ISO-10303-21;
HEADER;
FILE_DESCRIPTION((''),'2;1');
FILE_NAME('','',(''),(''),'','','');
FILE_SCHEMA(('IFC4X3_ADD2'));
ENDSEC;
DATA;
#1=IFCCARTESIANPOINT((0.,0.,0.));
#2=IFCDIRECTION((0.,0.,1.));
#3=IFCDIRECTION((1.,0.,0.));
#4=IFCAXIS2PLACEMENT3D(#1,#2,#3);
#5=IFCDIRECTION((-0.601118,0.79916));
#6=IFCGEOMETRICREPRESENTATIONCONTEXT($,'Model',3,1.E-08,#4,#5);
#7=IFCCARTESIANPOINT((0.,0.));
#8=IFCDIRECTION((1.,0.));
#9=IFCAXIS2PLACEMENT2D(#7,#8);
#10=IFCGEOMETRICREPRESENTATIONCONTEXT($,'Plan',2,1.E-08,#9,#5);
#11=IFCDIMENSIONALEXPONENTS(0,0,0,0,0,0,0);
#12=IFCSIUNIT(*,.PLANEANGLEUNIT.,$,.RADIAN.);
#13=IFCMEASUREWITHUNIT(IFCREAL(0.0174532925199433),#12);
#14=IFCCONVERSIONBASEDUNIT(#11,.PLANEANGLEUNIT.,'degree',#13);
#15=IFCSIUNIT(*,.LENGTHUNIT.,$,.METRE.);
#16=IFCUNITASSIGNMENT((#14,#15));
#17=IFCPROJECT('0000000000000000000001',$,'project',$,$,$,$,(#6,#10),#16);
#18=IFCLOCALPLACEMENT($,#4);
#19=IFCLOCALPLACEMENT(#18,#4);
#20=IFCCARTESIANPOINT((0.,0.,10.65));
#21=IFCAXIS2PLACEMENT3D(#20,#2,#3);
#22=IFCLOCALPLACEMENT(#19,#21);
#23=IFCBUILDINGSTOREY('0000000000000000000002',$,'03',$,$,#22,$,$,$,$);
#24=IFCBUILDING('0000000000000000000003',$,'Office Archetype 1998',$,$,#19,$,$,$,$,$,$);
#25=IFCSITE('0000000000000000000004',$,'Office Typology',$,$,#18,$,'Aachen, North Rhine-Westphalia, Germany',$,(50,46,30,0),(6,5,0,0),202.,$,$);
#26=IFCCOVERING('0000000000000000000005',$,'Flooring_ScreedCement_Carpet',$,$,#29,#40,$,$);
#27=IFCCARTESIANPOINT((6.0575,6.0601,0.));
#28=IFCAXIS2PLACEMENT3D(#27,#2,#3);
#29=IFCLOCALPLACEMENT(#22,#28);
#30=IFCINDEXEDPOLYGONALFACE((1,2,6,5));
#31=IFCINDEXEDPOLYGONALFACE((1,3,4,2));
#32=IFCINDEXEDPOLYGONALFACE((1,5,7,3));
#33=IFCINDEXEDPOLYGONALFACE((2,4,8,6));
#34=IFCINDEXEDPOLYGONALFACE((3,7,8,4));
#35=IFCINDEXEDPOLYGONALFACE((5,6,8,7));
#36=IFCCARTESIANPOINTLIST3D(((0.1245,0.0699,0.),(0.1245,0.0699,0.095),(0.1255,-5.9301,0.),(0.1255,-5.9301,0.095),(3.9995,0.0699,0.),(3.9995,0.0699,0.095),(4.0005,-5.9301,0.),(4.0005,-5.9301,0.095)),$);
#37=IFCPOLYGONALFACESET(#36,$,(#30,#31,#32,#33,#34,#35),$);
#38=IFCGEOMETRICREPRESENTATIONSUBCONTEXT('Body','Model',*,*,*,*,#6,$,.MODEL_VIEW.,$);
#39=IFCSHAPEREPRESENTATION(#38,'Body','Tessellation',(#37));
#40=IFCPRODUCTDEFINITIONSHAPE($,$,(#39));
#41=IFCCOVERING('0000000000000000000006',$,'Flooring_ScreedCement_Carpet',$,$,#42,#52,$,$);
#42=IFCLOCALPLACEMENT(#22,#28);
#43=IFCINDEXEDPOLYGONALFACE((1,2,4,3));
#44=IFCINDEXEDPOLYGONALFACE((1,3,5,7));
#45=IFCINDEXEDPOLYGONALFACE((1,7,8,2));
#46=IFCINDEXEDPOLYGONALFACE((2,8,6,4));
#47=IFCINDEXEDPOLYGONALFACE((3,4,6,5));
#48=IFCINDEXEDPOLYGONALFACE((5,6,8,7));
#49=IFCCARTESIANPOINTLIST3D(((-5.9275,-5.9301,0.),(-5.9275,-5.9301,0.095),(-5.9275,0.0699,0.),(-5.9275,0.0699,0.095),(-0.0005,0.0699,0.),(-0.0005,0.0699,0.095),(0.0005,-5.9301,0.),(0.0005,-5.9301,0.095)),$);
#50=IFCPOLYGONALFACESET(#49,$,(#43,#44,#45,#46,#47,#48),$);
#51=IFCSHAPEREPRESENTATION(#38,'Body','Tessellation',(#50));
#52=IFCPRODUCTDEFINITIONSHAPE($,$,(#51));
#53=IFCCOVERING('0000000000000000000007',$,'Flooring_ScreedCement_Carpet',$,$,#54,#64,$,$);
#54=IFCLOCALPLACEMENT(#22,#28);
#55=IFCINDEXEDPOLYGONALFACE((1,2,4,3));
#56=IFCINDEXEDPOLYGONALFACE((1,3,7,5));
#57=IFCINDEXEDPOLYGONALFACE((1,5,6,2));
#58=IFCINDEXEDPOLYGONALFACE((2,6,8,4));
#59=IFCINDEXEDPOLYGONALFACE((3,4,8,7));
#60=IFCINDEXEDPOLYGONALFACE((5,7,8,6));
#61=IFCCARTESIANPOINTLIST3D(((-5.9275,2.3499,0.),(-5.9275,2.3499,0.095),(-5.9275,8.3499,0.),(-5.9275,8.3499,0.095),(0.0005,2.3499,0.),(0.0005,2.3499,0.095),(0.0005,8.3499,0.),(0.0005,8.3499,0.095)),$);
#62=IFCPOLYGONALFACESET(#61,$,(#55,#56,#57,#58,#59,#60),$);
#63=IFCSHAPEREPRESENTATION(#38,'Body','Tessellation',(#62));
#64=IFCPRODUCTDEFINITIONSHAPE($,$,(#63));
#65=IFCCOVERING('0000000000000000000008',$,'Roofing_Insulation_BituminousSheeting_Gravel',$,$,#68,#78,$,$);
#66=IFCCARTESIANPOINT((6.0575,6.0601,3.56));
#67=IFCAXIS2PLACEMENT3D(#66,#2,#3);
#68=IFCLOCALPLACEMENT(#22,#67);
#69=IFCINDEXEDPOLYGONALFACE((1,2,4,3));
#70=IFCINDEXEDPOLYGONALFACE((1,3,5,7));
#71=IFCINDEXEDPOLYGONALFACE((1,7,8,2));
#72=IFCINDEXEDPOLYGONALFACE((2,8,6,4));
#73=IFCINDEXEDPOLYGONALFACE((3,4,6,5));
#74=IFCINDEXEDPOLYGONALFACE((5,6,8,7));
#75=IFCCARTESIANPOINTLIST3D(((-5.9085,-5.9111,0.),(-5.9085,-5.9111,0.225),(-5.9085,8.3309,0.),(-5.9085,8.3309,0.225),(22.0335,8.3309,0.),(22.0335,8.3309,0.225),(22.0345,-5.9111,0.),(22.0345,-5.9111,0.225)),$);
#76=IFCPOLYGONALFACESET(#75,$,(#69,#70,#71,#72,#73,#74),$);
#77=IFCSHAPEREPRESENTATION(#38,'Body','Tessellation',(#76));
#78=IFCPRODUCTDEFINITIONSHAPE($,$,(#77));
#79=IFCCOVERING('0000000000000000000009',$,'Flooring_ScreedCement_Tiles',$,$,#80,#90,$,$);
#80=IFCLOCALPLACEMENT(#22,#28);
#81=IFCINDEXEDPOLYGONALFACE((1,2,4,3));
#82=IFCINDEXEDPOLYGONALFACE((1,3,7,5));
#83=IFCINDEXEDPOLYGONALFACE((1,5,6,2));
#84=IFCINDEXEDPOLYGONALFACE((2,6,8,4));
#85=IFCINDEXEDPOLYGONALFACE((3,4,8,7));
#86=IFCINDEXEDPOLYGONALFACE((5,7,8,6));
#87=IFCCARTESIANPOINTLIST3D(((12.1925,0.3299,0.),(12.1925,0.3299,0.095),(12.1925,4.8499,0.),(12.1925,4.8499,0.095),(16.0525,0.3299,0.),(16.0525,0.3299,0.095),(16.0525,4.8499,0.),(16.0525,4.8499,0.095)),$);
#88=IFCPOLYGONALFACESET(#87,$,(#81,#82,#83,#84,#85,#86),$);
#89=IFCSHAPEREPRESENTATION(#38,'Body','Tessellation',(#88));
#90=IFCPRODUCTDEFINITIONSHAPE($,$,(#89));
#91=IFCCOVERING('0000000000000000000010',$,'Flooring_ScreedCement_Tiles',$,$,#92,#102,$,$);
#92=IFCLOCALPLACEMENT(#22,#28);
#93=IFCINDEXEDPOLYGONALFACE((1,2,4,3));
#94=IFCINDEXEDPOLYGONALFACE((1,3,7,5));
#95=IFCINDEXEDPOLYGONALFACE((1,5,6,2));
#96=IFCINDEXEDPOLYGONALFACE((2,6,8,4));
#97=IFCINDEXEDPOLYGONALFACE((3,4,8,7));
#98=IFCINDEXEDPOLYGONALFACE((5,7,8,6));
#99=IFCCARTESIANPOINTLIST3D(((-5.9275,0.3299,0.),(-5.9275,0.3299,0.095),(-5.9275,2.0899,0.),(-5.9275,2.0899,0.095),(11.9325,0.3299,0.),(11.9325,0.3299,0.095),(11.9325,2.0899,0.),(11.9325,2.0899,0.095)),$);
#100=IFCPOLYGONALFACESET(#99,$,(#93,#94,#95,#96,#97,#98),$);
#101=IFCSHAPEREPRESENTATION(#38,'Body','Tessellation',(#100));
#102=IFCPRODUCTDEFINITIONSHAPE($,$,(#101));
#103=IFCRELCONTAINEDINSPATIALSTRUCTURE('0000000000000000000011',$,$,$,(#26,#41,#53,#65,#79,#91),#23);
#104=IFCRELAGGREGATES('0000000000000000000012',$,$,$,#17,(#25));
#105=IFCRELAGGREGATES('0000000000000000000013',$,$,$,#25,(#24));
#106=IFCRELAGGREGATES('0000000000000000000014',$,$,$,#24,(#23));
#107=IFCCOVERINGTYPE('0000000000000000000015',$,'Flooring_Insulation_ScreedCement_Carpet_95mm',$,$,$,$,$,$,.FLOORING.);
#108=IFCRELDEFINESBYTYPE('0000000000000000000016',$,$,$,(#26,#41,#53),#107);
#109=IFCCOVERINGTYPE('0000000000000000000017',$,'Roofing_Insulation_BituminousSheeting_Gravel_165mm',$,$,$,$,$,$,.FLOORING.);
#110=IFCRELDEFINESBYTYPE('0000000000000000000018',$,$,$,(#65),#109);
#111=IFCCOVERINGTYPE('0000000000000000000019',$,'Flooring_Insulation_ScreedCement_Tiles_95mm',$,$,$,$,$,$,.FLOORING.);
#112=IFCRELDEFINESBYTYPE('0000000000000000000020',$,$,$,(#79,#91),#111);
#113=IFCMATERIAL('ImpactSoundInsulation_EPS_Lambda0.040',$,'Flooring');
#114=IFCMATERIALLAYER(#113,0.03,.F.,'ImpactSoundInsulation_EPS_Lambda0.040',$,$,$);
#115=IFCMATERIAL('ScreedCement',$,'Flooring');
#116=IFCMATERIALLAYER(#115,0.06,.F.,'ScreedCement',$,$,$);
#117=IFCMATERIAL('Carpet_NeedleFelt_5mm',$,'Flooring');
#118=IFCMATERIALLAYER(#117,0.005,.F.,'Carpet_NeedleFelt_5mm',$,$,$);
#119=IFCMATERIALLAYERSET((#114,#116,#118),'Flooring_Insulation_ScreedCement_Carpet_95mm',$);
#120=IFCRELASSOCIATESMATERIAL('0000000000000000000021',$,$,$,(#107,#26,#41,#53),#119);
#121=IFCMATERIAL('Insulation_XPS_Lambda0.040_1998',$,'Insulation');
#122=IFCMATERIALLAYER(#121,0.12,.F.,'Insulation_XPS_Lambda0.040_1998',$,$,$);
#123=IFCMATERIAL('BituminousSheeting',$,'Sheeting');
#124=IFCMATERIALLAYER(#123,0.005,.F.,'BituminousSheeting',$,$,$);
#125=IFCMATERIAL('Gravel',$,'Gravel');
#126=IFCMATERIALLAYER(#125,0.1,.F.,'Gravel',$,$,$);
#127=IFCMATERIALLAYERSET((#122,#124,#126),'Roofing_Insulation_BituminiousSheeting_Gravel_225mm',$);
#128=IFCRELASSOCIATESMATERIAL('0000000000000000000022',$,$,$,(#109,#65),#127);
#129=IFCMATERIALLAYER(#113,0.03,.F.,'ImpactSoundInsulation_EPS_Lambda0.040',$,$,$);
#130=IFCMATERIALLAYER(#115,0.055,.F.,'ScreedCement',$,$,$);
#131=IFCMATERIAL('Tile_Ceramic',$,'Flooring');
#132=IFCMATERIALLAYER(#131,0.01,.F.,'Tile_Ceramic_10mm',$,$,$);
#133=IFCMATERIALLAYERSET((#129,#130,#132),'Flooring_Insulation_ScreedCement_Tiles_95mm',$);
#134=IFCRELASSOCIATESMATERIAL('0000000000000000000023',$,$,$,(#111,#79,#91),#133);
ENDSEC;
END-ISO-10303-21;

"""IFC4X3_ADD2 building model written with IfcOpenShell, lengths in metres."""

from ifc_helpers import new_model, entity, si_unit, converted_unit, direction, frame, origin_with_axes, origin_2d_with_axis, place, context, subcontext, project, spatial, line, indexed_curve, outline, extrude, material, layer, layer_set, layer_usage, type_object, element, save


model = new_model("IFC4X3_ADD2")

# Units and contexts
model_context = context("Model", 3, precision=1e-08, world=origin_with_axes(), true_north=direction((-0.601118, 0.79916)))
plan_context = context("Plan", 2, precision=1e-08, world=origin_2d_with_axis(), true_north=direction((-0.601118, 0.79916)))
body_context = subcontext(model_context, "Body", "Model", "MODEL_VIEW")
ifc_project = project(units=[converted_unit("PLANEANGLEUNIT", "degree", entity("IfcReal", 0.0174532925199433), si_unit("PLANEANGLEUNIT", "RADIAN"), dimensions=[0, 0, 0, 0, 0, 0, 0]), si_unit("LENGTHUNIT", "METRE")], contexts=[model_context, plan_context])

# Site, building, storey
site_placement = place(None, origin_with_axes())
site = spatial("IfcSite", under=ifc_project, at=site_placement, Name="Office Typology", LongName="Aachen, North Rhine-Westphalia, Germany", RefLatitude=(50, 46, 30, 0), RefLongitude=(6, 5, 0, 0), RefElevation=202.0)
building_placement = place(site_placement, origin_with_axes())
building = spatial("IfcBuilding", under=site, at=building_placement, Name="Office Archetype 1998")
storey_placement = place(building_placement, frame((0.0, 0.0, 10.65), z_axis=(0.0, 0.0, 1.0), x_axis=(1.0, 0.0, 0.0)))
storey = spatial("IfcBuildingStorey", under=building, at=storey_placement, Name="03")

# Coverings
ifc_material_1 = material(Name="ImpactSoundInsulation_EPS_Lambda0.040", Category="Flooring")
ifc_layer_1 = layer(ifc_material_1, 0.03, ventilated=False, Name="ImpactSoundInsulation_EPS_Lambda0.040")
ifc_material_2 = material(Name="ScreedCement", Category="Flooring")
ifc_layer_2 = layer(ifc_material_2, 0.06, ventilated=False, Name="ScreedCement")
ifc_material_3 = material(Name="Carpet_NeedleFelt_5mm", Category="Flooring")
ifc_layer_3 = layer(ifc_material_3, 0.005, ventilated=False, Name="Carpet_NeedleFelt_5mm")
ifc_layer_set_1 = layer_set([ifc_layer_1, ifc_layer_2, ifc_layer_3], Name="Flooring_Insulation_ScreedCement_Carpet_95mm")
ifc_layer_usage_1 = layer_usage(ifc_layer_set_1, "AXIS3", "POSITIVE", 0.0)
covering_type_1 = type_object("IfcCoveringType", Name="Flooring_Insulation_ScreedCement_Carpet_95mm", PredefinedType="FLOORING", material=ifc_layer_set_1)
covering_1_placement = place(storey_placement, frame((6.0575, 6.0601, 0.0), z_axis=(0.0, 0.0, 1.0), x_axis=(1.0, 0.0, 0.0)))
element("IfcCovering", 1, at=covering_1_placement, inside=storey, type_object=covering_type_1, material=ifc_layer_usage_1, Name="Flooring_ScreedCement_Carpet", context=body_context, shape_type="SweptSolid", body=[
    extrude(outline(indexed_curve([(0.1255, -5.9301), (0.1245, 0.0699), (3.9995, 0.0699), (4.0005, -5.9301)], segments=[line(1, 2, 3, 4, 1)])), origin_with_axes(), (0.0, 0.0, 1.0), 0.095),
])
ifc_layer_usage_2 = layer_usage(ifc_layer_set_1, "AXIS3", "POSITIVE", 0.0)
covering_2_placement = place(storey_placement, frame((6.0575, 6.0601, 0.0), z_axis=(0.0, 0.0, 1.0), x_axis=(1.0, 0.0, 0.0)))
element("IfcCovering", 2, at=covering_2_placement, inside=storey, type_object=covering_type_1, material=ifc_layer_usage_2, Name="Flooring_ScreedCement_Carpet", context=body_context, shape_type="SweptSolid", body=[
    extrude(outline(indexed_curve([(-5.9275, -5.9301), (-5.9275, 0.0699), (-0.0005, 0.0699), (0.0005, -5.9301)], segments=[line(1, 2, 3, 4, 1)])), origin_with_axes(), (0.0, 0.0, 1.0), 0.095),
])
ifc_layer_usage_3 = layer_usage(ifc_layer_set_1, "AXIS3", "POSITIVE", 0.0)
covering_3_placement = place(storey_placement, frame((6.0575, 6.0601, 0.0), z_axis=(0.0, 0.0, 1.0), x_axis=(1.0, 0.0, 0.0)))
element("IfcCovering", 3, at=covering_3_placement, inside=storey, type_object=covering_type_1, material=ifc_layer_usage_3, Name="Flooring_ScreedCement_Carpet", context=body_context, shape_type="SweptSolid", body=[
    extrude(outline(indexed_curve([(0.0005, 2.3499), (-5.9275, 2.3499), (-5.9275, 8.3499), (0.0005, 8.3499), (0.0005, 2.3499)], segments=[line(1, 2, 3, 4, 5, 1)])), origin_with_axes(), (0.0, 0.0, 1.0), 0.095),
])
ifc_material_4 = material(Name="Insulation_XPS_Lambda0.040_1998", Category="Insulation")
ifc_layer_4 = layer(ifc_material_4, 0.12, ventilated=False, Name="Insulation_XPS_Lambda0.040_1998")
ifc_material_5 = material(Name="BituminousSheeting", Category="Sheeting")
ifc_layer_5 = layer(ifc_material_5, 0.005, ventilated=False, Name="BituminousSheeting")
ifc_material_6 = material(Name="Gravel", Category="Gravel")
ifc_layer_6 = layer(ifc_material_6, 0.1, ventilated=False, Name="Gravel")
ifc_layer_set_2 = layer_set([ifc_layer_4, ifc_layer_5, ifc_layer_6], Name="Roofing_Insulation_BituminiousSheeting_Gravel_225mm")
ifc_layer_usage_4 = layer_usage(ifc_layer_set_2, "AXIS3", "POSITIVE", 0.0)
covering_type_2 = type_object("IfcCoveringType", Name="Roofing_Insulation_BituminousSheeting_Gravel_165mm", PredefinedType="FLOORING", material=ifc_layer_set_2)
covering_4_placement = place(storey_placement, frame((6.0575, 6.0601, 3.56), z_axis=(0.0, 0.0, 1.0), x_axis=(1.0, 0.0, 0.0)))
element("IfcCovering", 4, at=covering_4_placement, inside=storey, type_object=covering_type_2, material=ifc_layer_usage_4, Name="Roofing_Insulation_BituminousSheeting_Gravel", context=body_context, shape_type="SweptSolid", body=[
    extrude(outline(indexed_curve([(22.0345, -5.9111), (22.0335, 8.3309), (-5.9085, 8.3309), (-5.9085, -5.9111), (22.0345, -5.9111)])), None, (0.0, 0.0, 1.0), 0.225),
])
ifc_layer_7 = layer(ifc_material_1, 0.03, ventilated=False, Name="ImpactSoundInsulation_EPS_Lambda0.040")
ifc_layer_8 = layer(ifc_material_2, 0.055, ventilated=False, Name="ScreedCement")
ifc_material_7 = material(Name="Tile_Ceramic", Category="Flooring")
ifc_layer_9 = layer(ifc_material_7, 0.01, ventilated=False, Name="Tile_Ceramic_10mm")
ifc_layer_set_3 = layer_set([ifc_layer_7, ifc_layer_8, ifc_layer_9], Name="Flooring_Insulation_ScreedCement_Tiles_95mm")
ifc_layer_usage_5 = layer_usage(ifc_layer_set_3, "AXIS3", "POSITIVE", 0.0)
covering_type_3 = type_object("IfcCoveringType", Name="Flooring_Insulation_ScreedCement_Tiles_95mm", PredefinedType="FLOORING", material=ifc_layer_set_3)
covering_5_placement = place(storey_placement, frame((6.0575, 6.0601, 0.0), z_axis=(0.0, 0.0, 1.0), x_axis=(1.0, 0.0, 0.0)))
element("IfcCovering", 5, at=covering_5_placement, inside=storey, type_object=covering_type_3, material=ifc_layer_usage_5, Name="Flooring_ScreedCement_Tiles", context=body_context, shape_type="SweptSolid", body=[
    extrude(outline(indexed_curve([(16.0525, 0.3299), (12.1925, 0.3299), (12.1925, 4.8499), (16.0525, 4.8499), (16.0525, 0.3299)], segments=[line(1, 2, 3, 4, 5, 1)])), origin_with_axes(), (0.0, 0.0, 1.0), 0.095),
])
ifc_layer_usage_6 = layer_usage(ifc_layer_set_3, "AXIS3", "POSITIVE", 0.0)
covering_6_placement = place(storey_placement, frame((6.0575, 6.0601, 0.0), z_axis=(0.0, 0.0, 1.0), x_axis=(1.0, 0.0, 0.0)))
element("IfcCovering", 6, at=covering_6_placement, inside=storey, type_object=covering_type_3, material=ifc_layer_usage_6, Name="Flooring_ScreedCement_Tiles", context=body_context, shape_type="SweptSolid", body=[
    extrude(outline(indexed_curve([(-5.9275, 0.3299), (-5.9275, 2.0899), (11.9325, 2.0899), (11.9325, 0.3299)], segments=[line(1, 2, 3, 4, 1)])), None, (0.0, 0.0, 1.0), 0.095),
])

save(model, "model.ifc")
